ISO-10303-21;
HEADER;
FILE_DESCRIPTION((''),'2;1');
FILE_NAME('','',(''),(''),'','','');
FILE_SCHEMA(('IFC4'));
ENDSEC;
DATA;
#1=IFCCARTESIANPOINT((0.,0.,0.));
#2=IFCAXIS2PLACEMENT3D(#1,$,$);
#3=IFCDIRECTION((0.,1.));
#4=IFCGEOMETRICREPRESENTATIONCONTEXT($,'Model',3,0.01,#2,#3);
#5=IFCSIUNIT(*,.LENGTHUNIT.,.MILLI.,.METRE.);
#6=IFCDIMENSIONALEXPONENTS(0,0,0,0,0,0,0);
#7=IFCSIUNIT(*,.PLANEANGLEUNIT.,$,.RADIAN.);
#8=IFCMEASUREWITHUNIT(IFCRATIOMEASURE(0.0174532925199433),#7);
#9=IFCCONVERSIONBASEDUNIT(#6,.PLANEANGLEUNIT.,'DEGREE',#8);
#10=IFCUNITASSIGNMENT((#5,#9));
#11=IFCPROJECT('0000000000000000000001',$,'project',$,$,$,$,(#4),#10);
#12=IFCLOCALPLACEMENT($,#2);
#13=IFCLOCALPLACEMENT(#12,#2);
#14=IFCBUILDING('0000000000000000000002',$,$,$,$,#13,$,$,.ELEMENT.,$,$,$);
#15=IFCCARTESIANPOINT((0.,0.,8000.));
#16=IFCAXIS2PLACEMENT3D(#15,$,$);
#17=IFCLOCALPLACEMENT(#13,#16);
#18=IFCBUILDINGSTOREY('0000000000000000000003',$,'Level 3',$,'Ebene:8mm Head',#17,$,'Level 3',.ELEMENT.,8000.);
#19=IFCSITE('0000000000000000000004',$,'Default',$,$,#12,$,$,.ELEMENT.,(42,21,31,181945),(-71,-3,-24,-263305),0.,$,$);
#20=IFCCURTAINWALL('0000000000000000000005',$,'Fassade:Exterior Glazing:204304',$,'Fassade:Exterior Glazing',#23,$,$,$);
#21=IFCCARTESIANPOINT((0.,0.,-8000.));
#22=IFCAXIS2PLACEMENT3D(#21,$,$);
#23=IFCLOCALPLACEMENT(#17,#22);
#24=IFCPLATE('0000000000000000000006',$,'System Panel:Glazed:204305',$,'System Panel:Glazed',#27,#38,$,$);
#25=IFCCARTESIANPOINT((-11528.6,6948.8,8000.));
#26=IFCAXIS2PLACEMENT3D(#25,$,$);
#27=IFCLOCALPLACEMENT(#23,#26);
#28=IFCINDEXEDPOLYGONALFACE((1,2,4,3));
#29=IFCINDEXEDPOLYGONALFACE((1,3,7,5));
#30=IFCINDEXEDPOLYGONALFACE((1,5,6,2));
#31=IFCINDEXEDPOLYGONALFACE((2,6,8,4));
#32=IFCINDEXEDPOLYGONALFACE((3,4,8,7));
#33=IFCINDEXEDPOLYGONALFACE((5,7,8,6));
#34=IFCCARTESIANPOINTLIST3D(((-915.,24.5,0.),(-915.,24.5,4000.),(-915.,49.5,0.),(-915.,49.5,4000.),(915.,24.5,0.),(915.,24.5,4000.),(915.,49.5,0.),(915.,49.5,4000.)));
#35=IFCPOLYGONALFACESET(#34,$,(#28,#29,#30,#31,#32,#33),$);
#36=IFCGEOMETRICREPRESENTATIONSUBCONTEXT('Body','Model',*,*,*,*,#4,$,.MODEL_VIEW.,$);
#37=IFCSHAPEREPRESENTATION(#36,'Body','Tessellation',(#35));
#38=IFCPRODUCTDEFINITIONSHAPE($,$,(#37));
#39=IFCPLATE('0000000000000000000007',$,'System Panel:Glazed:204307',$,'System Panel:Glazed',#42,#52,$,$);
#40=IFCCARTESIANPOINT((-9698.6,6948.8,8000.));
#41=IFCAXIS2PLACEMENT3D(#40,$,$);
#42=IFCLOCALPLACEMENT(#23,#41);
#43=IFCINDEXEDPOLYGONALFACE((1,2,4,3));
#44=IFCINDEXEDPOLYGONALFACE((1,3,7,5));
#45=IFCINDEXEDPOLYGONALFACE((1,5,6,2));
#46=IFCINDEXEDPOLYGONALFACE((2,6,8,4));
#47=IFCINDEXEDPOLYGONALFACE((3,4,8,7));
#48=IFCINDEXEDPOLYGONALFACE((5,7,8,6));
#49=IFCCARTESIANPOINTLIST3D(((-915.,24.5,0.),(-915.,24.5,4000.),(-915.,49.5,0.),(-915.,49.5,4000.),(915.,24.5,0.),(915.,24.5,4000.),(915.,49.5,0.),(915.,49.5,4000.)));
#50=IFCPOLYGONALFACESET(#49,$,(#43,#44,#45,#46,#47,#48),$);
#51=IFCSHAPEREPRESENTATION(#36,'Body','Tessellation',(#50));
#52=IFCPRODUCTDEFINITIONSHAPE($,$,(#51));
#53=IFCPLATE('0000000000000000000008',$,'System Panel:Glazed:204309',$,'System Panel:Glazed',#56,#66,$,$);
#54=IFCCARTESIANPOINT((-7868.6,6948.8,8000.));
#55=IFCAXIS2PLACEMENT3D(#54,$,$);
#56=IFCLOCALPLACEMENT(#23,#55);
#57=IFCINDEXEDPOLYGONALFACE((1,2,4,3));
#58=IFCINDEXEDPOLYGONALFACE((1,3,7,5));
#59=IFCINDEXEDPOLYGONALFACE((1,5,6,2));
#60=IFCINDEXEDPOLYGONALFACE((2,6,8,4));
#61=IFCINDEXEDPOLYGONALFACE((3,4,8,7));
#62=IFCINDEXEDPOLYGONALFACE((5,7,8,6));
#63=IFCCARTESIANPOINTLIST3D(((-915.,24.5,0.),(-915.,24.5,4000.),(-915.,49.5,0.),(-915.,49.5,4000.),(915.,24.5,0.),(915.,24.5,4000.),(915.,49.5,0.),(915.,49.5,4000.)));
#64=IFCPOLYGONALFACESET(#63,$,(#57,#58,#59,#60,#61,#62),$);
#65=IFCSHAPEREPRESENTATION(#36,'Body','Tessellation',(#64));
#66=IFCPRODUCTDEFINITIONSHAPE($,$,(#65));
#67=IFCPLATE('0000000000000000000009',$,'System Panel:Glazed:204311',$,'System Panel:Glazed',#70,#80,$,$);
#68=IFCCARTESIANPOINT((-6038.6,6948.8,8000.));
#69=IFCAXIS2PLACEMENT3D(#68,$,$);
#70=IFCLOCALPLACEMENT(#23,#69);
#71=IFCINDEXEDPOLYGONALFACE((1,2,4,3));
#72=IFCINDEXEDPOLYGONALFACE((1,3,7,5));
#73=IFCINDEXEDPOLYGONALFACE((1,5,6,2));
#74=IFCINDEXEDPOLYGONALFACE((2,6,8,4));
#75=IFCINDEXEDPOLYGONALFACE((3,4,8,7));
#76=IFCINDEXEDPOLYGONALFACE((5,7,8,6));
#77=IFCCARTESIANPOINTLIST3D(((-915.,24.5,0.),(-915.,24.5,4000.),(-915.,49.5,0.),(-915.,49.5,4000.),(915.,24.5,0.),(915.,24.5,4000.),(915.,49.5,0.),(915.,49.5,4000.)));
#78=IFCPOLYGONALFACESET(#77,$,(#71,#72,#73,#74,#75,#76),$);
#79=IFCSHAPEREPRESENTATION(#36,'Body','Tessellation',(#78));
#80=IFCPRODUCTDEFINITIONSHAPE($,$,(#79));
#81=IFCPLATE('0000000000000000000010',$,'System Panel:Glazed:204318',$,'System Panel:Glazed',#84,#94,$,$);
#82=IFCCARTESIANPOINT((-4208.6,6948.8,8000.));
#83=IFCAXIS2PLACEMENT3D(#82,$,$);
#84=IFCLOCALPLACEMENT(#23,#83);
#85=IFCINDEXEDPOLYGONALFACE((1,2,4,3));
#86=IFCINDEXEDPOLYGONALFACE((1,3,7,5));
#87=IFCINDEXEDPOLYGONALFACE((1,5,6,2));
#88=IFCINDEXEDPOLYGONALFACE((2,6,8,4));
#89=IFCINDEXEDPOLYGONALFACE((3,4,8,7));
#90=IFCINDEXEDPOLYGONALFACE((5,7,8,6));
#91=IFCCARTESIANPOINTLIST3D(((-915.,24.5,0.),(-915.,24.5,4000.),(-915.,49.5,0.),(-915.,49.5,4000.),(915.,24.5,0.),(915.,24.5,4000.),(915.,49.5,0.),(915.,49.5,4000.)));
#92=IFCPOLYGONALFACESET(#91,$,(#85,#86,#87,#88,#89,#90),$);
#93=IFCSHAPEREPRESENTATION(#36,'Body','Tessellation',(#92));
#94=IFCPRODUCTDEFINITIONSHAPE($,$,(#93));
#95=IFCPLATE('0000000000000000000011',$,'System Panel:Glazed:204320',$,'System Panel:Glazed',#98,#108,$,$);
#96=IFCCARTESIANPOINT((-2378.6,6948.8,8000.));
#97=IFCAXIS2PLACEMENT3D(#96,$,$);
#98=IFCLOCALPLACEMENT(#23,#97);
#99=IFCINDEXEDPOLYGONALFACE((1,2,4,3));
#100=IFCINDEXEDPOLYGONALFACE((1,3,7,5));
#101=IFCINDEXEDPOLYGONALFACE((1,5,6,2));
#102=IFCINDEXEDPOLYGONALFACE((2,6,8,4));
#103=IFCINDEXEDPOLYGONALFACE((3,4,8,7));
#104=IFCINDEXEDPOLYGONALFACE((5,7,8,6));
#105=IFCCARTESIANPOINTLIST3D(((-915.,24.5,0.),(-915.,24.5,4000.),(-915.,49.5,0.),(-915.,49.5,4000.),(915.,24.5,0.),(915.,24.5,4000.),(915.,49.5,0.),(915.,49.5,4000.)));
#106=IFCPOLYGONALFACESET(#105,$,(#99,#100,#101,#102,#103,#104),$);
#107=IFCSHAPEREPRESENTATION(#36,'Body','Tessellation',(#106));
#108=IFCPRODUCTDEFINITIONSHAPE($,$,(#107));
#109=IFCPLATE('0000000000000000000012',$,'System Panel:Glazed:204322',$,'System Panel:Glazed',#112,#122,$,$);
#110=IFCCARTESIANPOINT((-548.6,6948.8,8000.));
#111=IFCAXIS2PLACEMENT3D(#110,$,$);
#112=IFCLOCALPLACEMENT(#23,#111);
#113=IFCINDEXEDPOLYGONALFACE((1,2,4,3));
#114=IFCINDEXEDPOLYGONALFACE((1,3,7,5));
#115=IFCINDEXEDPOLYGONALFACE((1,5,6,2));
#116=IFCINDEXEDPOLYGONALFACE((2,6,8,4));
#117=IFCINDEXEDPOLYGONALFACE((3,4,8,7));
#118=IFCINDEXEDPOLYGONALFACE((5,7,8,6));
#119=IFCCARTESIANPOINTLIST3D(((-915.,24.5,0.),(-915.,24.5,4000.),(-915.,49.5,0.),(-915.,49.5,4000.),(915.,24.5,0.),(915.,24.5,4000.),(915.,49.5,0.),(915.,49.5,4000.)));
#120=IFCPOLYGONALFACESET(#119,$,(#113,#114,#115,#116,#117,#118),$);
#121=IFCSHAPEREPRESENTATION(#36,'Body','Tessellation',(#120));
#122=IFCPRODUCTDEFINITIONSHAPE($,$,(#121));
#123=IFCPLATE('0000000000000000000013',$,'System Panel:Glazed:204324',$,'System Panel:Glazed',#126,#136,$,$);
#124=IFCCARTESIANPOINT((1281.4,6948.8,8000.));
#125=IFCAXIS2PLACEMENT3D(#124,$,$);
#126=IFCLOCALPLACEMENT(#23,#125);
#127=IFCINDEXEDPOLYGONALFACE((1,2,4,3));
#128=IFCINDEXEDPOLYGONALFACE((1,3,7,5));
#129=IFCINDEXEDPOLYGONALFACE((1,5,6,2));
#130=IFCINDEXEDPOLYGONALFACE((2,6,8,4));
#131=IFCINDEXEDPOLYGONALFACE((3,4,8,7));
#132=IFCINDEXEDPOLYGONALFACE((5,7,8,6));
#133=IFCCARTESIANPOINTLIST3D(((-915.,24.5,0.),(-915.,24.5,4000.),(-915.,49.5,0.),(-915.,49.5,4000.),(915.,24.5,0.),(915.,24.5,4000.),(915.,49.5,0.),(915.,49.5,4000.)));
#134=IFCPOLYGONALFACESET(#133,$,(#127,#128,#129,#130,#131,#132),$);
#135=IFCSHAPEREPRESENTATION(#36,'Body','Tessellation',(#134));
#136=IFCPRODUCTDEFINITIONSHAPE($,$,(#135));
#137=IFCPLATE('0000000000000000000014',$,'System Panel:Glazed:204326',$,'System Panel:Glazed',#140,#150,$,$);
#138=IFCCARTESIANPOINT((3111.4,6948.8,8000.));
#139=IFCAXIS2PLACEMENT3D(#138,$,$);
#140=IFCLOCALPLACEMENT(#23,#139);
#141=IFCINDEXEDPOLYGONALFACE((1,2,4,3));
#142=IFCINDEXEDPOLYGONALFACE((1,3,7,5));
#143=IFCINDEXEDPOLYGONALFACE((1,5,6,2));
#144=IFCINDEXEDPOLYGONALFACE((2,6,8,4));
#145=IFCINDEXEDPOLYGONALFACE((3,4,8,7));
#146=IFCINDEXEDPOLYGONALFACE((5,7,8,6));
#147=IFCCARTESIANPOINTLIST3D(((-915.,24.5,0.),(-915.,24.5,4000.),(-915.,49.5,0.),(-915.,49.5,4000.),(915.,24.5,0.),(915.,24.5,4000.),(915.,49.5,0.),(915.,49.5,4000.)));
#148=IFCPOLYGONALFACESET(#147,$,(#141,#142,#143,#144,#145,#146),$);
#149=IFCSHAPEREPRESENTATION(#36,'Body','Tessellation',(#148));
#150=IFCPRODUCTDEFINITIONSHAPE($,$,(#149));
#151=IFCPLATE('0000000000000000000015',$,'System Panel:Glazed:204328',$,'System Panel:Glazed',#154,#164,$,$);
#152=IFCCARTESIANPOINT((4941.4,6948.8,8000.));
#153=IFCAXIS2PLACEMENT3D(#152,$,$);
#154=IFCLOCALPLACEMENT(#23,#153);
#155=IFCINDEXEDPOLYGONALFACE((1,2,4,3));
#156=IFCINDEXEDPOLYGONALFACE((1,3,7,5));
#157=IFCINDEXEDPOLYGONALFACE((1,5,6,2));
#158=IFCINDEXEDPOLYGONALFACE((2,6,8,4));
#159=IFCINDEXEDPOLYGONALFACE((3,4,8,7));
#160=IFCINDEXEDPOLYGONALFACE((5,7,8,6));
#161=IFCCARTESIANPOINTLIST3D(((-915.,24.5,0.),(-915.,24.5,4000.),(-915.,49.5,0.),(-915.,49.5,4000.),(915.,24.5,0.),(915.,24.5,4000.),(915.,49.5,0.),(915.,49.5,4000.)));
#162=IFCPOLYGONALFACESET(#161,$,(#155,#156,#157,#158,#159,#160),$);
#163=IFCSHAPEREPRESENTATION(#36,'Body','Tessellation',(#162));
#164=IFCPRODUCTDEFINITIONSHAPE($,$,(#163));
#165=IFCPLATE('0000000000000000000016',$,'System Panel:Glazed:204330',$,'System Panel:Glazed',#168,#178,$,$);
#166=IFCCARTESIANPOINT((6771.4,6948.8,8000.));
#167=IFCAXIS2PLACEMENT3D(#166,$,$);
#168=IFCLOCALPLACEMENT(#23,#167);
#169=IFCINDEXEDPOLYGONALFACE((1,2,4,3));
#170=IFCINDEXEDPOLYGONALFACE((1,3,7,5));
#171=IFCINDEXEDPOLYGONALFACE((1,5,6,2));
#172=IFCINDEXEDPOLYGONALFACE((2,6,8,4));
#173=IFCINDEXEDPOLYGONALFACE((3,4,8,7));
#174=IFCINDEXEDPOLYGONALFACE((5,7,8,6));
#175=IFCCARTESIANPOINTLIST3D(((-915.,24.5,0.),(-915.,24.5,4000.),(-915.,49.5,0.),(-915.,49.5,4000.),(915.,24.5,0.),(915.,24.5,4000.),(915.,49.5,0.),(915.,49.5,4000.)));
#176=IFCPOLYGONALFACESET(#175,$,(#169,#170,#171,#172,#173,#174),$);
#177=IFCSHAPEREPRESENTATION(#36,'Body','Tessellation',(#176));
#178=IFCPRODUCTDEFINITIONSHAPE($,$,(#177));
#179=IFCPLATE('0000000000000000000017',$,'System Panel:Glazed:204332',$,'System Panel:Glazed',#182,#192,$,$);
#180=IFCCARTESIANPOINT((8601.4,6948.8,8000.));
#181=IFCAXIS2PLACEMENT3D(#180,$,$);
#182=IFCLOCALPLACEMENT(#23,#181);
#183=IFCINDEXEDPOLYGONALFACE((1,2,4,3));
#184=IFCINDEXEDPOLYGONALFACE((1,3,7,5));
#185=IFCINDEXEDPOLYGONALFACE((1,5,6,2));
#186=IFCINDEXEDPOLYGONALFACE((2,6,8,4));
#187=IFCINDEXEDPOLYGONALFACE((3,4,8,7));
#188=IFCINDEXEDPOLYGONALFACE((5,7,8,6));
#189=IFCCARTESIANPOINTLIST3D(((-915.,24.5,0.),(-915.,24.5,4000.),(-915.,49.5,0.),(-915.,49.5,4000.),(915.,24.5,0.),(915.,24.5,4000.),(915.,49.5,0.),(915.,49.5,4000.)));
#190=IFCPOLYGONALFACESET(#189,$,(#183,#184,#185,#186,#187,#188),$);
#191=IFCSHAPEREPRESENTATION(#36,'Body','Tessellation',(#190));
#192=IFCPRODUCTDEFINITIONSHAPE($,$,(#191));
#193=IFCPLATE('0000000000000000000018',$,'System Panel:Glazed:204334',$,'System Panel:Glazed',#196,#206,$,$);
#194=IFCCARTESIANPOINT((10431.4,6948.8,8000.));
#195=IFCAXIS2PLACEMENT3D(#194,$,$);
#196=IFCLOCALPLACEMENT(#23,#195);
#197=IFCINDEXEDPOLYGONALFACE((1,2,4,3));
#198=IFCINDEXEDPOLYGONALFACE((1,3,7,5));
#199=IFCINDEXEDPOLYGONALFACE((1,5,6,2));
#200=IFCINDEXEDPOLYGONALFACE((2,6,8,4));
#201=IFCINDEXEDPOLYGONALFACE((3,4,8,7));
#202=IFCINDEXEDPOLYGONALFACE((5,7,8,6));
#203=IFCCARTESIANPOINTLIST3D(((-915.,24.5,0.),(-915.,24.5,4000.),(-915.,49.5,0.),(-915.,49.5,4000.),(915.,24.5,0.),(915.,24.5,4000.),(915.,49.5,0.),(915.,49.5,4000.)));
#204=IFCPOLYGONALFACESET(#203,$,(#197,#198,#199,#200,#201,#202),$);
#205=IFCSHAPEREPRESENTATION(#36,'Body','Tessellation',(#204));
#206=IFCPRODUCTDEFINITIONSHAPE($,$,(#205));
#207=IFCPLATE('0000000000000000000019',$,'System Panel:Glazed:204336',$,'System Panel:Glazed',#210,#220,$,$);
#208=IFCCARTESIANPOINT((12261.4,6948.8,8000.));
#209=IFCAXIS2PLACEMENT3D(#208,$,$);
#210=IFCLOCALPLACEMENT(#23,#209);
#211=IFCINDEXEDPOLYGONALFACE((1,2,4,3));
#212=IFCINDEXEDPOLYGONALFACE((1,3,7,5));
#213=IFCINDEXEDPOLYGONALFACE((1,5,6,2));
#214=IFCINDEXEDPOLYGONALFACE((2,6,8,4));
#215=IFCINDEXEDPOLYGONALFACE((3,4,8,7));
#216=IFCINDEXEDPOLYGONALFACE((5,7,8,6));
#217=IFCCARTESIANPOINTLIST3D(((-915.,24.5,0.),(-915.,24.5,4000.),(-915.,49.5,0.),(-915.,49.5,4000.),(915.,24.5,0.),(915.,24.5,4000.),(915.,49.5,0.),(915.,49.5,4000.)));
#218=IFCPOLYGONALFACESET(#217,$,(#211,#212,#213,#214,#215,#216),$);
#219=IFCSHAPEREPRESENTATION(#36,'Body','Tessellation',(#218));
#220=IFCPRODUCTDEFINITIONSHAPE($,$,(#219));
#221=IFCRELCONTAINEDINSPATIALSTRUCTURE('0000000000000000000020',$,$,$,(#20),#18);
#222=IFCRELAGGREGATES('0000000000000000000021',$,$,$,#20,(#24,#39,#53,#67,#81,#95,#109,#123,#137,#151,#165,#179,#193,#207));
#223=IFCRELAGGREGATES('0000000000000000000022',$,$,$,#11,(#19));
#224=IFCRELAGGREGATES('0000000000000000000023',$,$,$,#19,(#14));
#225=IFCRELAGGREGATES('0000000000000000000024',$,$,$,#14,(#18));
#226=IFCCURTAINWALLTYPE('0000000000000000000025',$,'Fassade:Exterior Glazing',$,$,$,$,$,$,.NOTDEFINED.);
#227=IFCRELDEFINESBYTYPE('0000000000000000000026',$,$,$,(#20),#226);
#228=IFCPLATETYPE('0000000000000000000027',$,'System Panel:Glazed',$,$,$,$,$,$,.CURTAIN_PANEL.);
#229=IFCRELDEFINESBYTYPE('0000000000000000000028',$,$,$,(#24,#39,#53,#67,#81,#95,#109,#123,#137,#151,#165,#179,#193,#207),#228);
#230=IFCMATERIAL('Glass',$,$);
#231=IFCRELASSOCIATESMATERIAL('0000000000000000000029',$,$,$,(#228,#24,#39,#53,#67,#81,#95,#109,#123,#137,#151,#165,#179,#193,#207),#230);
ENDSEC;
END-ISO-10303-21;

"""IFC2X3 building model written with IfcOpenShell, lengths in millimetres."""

from ifc_helpers import new_model, entity, si_unit, converted_unit, direction, frame, origin, origin_2d_with_axis, place, context, subcontext, project, spatial, rectangle, extrude, source, transform, mapped, material, type_object, type_shapes, element, aggregate, save


model = new_model("IFC2X3")

# Units and contexts
model_context = context("Model", 3, precision=0.01, world=origin(), true_north=direction((0.0, 1.0)))
body_context = subcontext(model_context, "Body", "Model", "MODEL_VIEW")
ifc_project = project(units=[si_unit("LENGTHUNIT", "METRE", prefix="MILLI"), converted_unit("PLANEANGLEUNIT", "DEGREE", entity("IfcRatioMeasure", 0.0174532925199433), si_unit("PLANEANGLEUNIT", "RADIAN"), dimensions=[0, 0, 0, 0, 0, 0, 0])], contexts=[model_context])

# Site, building, storey
site_placement = place(None, origin())
site = spatial("IfcSite", under=ifc_project, at=site_placement, Name="Default", CompositionType="ELEMENT", RefLatitude=(42, 21, 31, 181945), RefLongitude=(-71, -3, -24, -263305), RefElevation=0.0)
building_placement = place(site_placement, origin())
building = spatial("IfcBuilding", under=site, at=building_placement, CompositionType="ELEMENT")
storey_placement = place(building_placement, frame((0.0, 0.0, 8000.0)))
storey = spatial("IfcBuildingStorey", under=building, at=storey_placement, Name="Level 3", ObjectType="Ebene:8mm Head", LongName="Level 3", CompositionType="ELEMENT", Elevation=8000.0)

# Curtain wall, plates
curtain_wall_type = type_object("IfcCurtainWallType", Name="Fassade:Exterior Glazing", PredefinedType="NOTDEFINED")
curtain_wall_placement = place(storey_placement, frame((0.0, 0.0, -8000.0)))
curtain_wall = element("IfcCurtainWall", 1, at=curtain_wall_placement, inside=storey, type_object=curtain_wall_type, Name="Fassade:Exterior Glazing:204304", ObjectType="Fassade:Exterior Glazing")
ifc_material_1 = material(Name="Glass")
plate_type_1 = type_object("IfcPlateType", Name="System Panel:Glazed", PredefinedType="CURTAIN_PANEL", material=ifc_material_1)
shared_shape_1 = source(origin(), body_context, "Body", "SweptSolid", [
    extrude(rectangle(XDim=25.0, YDim=1830.0, at=origin_2d_with_axis()), frame((0.0, 37.0, 0.0), z_axis=(0.0, 0.0, 1.0), x_axis=(0.0, 1.0, 0.0)), (0.0, 0.0, 1.0), 4000.0),
])
type_shapes(plate_type_1, [shared_shape_1])
plate_1_placement = place(curtain_wall_placement, frame((-11528.6, 6948.8, 8000.0)))
plate_1 = element("IfcPlate", 2, at=plate_1_placement, type_object=plate_type_1, material=ifc_material_1, Name="System Panel:Glazed:204305", ObjectType="System Panel:Glazed", context=body_context, shape_type="MappedRepresentation", body=[
    mapped(shared_shape_1, transform((0.0, 0.0, 0.0), scale=1.0)),
])
plate_2_placement = place(curtain_wall_placement, frame((-9698.6, 6948.8, 8000.0)))
plate_2 = element("IfcPlate", 3, at=plate_2_placement, type_object=plate_type_1, material=ifc_material_1, Name="System Panel:Glazed:204307", ObjectType="System Panel:Glazed", context=body_context, shape_type="MappedRepresentation", body=[
    mapped(shared_shape_1, transform((0.0, 0.0, 0.0), scale=1.0)),
])
plate_3_placement = place(curtain_wall_placement, frame((-7868.6, 6948.8, 8000.0)))
plate_3 = element("IfcPlate", 4, at=plate_3_placement, type_object=plate_type_1, material=ifc_material_1, Name="System Panel:Glazed:204309", ObjectType="System Panel:Glazed", context=body_context, shape_type="MappedRepresentation", body=[
    mapped(shared_shape_1, transform((0.0, 0.0, 0.0), scale=1.0)),
])
plate_4_placement = place(curtain_wall_placement, frame((-6038.6, 6948.8, 8000.0)))
plate_4 = element("IfcPlate", 5, at=plate_4_placement, type_object=plate_type_1, material=ifc_material_1, Name="System Panel:Glazed:204311", ObjectType="System Panel:Glazed", context=body_context, shape_type="MappedRepresentation", body=[
    mapped(shared_shape_1, transform((0.0, 0.0, 0.0), scale=1.0)),
])
plate_5_placement = place(curtain_wall_placement, frame((-4208.6, 6948.8, 8000.0)))
plate_5 = element("IfcPlate", 6, at=plate_5_placement, type_object=plate_type_1, material=ifc_material_1, Name="System Panel:Glazed:204318", ObjectType="System Panel:Glazed", context=body_context, shape_type="MappedRepresentation", body=[
    mapped(shared_shape_1, transform((0.0, 0.0, 0.0), scale=1.0)),
])
plate_6_placement = place(curtain_wall_placement, frame((-2378.6, 6948.8, 8000.0)))
plate_6 = element("IfcPlate", 7, at=plate_6_placement, type_object=plate_type_1, material=ifc_material_1, Name="System Panel:Glazed:204320", ObjectType="System Panel:Glazed", context=body_context, shape_type="MappedRepresentation", body=[
    mapped(shared_shape_1, transform((0.0, 0.0, 0.0), scale=1.0)),
])
plate_7_placement = place(curtain_wall_placement, frame((-548.6, 6948.8, 8000.0)))
plate_7 = element("IfcPlate", 8, at=plate_7_placement, type_object=plate_type_1, material=ifc_material_1, Name="System Panel:Glazed:204322", ObjectType="System Panel:Glazed", context=body_context, shape_type="MappedRepresentation", body=[
    mapped(shared_shape_1, transform((0.0, 0.0, 0.0), scale=1.0)),
])
plate_8_placement = place(curtain_wall_placement, frame((1281.4, 6948.8, 8000.0)))
plate_8 = element("IfcPlate", 9, at=plate_8_placement, type_object=plate_type_1, material=ifc_material_1, Name="System Panel:Glazed:204324", ObjectType="System Panel:Glazed", context=body_context, shape_type="MappedRepresentation", body=[
    mapped(shared_shape_1, transform((0.0, 0.0, 0.0), scale=1.0)),
])
plate_9_placement = place(curtain_wall_placement, frame((3111.4, 6948.8, 8000.0)))
plate_9 = element("IfcPlate", 10, at=plate_9_placement, type_object=plate_type_1, material=ifc_material_1, Name="System Panel:Glazed:204326", ObjectType="System Panel:Glazed", context=body_context, shape_type="MappedRepresentation", body=[
    mapped(shared_shape_1, transform((0.0, 0.0, 0.0), scale=1.0)),
])
plate_10_placement = place(curtain_wall_placement, frame((4941.4, 6948.8, 8000.0)))
plate_10 = element("IfcPlate", 11, at=plate_10_placement, type_object=plate_type_1, material=ifc_material_1, Name="System Panel:Glazed:204328", ObjectType="System Panel:Glazed", context=body_context, shape_type="MappedRepresentation", body=[
    mapped(shared_shape_1, transform((0.0, 0.0, 0.0), scale=1.0)),
])
plate_11_placement = place(curtain_wall_placement, frame((6771.4, 6948.8, 8000.0)))
plate_11 = element("IfcPlate", 12, at=plate_11_placement, type_object=plate_type_1, material=ifc_material_1, Name="System Panel:Glazed:204330", ObjectType="System Panel:Glazed", context=body_context, shape_type="MappedRepresentation", body=[
    mapped(shared_shape_1, transform((0.0, 0.0, 0.0), scale=1.0)),
])
plate_12_placement = place(curtain_wall_placement, frame((8601.4, 6948.8, 8000.0)))
plate_12 = element("IfcPlate", 13, at=plate_12_placement, type_object=plate_type_1, material=ifc_material_1, Name="System Panel:Glazed:204332", ObjectType="System Panel:Glazed", context=body_context, shape_type="MappedRepresentation", body=[
    mapped(shared_shape_1, transform((0.0, 0.0, 0.0), scale=1.0)),
])
plate_13_placement = place(curtain_wall_placement, frame((10431.4, 6948.8, 8000.0)))
plate_13 = element("IfcPlate", 14, at=plate_13_placement, type_object=plate_type_1, material=ifc_material_1, Name="System Panel:Glazed:204334", ObjectType="System Panel:Glazed", context=body_context, shape_type="MappedRepresentation", body=[
    mapped(shared_shape_1, transform((0.0, 0.0, 0.0), scale=1.0)),
])
plate_14_placement = place(curtain_wall_placement, frame((12261.4, 6948.8, 8000.0)))
plate_14 = element("IfcPlate", 15, at=plate_14_placement, type_object=plate_type_1, material=ifc_material_1, Name="System Panel:Glazed:204336", ObjectType="System Panel:Glazed", context=body_context, shape_type="MappedRepresentation", body=[
    mapped(shared_shape_1, transform((0.0, 0.0, 0.0), scale=1.0)),
])
aggregate(curtain_wall, [plate_1, plate_2, plate_3, plate_4, plate_5, plate_6, plate_7, plate_8, plate_9, plate_10, plate_11, plate_12, plate_13, plate_14])

save(model, "model.ifc")
